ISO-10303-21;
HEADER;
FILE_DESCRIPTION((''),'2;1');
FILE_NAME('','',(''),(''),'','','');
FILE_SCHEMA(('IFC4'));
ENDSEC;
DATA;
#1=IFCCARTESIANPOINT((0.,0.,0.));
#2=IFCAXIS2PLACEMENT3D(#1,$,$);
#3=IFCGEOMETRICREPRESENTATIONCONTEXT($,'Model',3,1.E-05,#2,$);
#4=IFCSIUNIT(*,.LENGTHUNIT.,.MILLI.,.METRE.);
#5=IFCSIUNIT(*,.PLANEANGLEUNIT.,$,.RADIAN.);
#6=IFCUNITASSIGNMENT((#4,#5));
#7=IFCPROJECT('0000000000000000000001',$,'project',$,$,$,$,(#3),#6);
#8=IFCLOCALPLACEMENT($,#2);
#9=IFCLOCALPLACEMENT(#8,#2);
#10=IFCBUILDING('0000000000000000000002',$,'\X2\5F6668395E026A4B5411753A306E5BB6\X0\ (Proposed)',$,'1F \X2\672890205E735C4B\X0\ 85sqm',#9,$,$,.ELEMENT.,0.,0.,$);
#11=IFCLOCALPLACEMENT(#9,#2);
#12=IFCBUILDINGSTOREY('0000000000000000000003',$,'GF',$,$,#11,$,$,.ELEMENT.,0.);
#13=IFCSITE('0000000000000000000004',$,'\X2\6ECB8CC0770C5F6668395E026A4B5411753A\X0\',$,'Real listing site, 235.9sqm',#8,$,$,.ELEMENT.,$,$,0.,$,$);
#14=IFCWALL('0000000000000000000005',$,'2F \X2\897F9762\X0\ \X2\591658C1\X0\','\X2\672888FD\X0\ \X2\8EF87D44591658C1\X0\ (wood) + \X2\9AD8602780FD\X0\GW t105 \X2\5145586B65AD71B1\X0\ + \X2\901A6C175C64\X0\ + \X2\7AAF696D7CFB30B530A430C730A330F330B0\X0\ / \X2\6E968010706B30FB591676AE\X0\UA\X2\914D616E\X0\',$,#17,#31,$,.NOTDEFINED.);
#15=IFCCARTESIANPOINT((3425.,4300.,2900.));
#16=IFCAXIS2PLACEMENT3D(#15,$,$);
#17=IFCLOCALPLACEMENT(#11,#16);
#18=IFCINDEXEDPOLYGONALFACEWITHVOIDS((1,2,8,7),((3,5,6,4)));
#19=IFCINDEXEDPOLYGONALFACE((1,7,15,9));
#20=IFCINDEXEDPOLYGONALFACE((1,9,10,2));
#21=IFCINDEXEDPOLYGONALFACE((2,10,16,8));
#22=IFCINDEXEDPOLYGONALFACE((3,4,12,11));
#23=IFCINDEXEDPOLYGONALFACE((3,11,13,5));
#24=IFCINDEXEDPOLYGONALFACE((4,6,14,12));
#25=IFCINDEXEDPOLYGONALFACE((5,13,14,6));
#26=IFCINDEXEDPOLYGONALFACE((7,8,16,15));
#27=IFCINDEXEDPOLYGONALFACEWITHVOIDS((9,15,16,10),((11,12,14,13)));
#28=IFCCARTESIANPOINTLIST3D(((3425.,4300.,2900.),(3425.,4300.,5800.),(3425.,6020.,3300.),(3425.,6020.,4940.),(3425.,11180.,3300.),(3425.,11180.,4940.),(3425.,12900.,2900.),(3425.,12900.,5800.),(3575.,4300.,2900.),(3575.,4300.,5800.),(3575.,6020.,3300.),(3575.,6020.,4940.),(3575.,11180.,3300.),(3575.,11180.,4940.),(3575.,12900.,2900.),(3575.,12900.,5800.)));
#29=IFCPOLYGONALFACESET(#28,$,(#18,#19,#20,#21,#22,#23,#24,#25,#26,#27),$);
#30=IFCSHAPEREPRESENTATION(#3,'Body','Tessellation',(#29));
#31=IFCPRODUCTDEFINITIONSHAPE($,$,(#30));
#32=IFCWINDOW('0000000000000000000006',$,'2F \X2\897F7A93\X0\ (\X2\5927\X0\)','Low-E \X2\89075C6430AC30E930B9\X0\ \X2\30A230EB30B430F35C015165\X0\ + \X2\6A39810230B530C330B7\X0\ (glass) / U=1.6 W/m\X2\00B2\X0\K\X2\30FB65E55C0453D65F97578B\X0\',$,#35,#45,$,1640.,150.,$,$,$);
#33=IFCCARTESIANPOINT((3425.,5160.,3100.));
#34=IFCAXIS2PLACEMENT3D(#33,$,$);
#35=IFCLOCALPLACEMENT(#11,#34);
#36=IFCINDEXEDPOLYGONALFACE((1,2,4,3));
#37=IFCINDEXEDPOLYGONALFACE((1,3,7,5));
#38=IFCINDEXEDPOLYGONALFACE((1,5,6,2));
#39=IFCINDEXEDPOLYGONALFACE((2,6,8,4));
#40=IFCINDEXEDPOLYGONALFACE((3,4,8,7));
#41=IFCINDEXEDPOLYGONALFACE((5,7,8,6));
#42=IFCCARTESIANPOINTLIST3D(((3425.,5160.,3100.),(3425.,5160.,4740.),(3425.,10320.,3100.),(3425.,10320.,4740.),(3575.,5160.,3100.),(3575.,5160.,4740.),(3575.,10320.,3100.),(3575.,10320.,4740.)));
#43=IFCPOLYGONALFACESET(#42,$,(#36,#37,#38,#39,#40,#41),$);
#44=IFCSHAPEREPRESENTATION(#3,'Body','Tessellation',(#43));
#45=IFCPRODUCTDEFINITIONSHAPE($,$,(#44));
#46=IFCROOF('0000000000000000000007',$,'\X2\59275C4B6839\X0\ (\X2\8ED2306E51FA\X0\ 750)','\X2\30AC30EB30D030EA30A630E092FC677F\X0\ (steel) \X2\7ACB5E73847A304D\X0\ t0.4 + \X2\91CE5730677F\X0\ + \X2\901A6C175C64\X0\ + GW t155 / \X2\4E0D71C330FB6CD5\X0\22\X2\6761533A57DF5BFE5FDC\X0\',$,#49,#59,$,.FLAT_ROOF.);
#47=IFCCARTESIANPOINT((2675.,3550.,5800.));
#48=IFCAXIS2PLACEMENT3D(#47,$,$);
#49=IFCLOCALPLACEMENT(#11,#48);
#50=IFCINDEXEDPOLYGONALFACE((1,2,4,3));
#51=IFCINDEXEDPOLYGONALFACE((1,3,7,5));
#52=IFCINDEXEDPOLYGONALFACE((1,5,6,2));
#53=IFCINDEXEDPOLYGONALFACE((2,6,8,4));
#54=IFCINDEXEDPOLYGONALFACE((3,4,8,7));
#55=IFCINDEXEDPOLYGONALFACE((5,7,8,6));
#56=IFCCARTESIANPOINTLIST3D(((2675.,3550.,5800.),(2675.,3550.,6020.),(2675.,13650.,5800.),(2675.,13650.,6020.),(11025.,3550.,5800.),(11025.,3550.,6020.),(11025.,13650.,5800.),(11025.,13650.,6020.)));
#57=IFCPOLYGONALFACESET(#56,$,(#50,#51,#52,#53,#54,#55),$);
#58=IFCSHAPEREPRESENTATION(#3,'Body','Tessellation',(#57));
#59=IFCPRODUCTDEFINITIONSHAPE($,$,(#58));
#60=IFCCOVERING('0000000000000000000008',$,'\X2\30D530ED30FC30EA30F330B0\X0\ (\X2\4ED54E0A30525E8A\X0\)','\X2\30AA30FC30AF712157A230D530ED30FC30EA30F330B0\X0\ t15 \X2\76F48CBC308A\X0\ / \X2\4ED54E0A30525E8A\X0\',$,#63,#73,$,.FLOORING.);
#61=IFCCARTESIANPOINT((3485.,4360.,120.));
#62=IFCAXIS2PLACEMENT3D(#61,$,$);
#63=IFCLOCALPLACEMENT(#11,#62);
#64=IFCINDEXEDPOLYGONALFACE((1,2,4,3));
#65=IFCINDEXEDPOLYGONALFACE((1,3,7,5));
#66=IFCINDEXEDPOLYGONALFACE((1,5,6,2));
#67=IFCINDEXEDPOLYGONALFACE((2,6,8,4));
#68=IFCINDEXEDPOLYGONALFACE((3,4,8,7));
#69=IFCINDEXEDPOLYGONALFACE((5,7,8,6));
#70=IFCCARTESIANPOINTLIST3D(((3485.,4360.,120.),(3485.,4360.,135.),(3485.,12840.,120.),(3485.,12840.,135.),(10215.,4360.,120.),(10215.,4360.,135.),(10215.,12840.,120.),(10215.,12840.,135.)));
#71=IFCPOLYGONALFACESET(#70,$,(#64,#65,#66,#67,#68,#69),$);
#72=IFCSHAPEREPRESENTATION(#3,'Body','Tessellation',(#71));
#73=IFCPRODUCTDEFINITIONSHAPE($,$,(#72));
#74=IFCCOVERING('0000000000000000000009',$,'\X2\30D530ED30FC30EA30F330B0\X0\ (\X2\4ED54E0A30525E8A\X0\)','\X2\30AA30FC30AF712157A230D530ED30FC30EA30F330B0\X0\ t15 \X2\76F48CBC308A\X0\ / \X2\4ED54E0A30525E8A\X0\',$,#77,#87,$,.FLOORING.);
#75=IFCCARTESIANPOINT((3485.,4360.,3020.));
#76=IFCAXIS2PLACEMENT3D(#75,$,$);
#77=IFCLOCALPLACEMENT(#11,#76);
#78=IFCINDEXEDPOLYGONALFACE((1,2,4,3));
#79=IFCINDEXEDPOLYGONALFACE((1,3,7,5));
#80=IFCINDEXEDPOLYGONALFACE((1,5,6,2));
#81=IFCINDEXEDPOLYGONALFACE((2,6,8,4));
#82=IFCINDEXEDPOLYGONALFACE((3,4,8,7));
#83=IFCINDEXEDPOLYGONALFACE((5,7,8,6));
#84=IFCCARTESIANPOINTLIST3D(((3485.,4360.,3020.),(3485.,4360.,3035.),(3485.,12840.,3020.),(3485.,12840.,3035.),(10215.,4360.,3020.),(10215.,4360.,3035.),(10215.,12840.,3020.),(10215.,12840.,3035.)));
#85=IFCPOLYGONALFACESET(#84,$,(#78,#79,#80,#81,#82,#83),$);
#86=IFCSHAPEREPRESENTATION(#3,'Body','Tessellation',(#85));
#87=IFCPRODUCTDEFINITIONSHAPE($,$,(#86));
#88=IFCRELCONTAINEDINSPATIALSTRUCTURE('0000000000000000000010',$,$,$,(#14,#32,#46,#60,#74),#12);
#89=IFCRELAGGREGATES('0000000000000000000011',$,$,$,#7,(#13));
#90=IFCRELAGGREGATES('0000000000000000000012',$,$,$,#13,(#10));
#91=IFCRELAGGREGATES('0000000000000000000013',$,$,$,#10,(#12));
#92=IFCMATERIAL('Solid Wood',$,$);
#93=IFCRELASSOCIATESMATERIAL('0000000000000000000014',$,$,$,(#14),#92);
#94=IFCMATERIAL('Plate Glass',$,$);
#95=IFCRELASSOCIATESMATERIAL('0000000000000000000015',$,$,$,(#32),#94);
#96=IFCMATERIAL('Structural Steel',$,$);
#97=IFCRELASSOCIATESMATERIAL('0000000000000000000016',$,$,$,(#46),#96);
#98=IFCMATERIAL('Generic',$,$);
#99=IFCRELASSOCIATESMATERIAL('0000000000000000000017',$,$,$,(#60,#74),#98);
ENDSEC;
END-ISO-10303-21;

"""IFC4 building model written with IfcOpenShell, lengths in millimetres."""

from ifc_helpers import new_model, si_unit, frame, frame_2d, origin, place, context, project, spatial, rectangle, extrude, material, element, fill, save


model = new_model("IFC4")

# Units and contexts
model_context = context("Model", 3, precision=1e-05, world=origin())
ifc_project = project(units=[si_unit("LENGTHUNIT", "METRE", prefix="MILLI"), si_unit("PLANEANGLEUNIT", "RADIAN")], contexts=[model_context])

# Site, building, storey
site_placement = place(None, origin())
site = spatial("IfcSite", under=ifc_project, at=site_placement, Name="滋賀県彦根市橋向町", ObjectType="Real listing site, 235.9sqm", CompositionType="ELEMENT", RefElevation=0.0)
building_placement = place(site_placement, origin())
building = spatial("IfcBuilding", under=site, at=building_placement, Name="彦根市橋向町の家 (Proposed)", ObjectType="1F 木造平屋 85sqm", CompositionType="ELEMENT", ElevationOfRefHeight=0.0, ElevationOfTerrain=0.0)
storey_placement = place(building_placement, origin())
storey = spatial("IfcBuildingStorey", under=building, at=storey_placement, Name="GF", CompositionType="ELEMENT", Elevation=0.0)

# Shared definitions
ifc_material_1 = material(Name="Solid Wood")
ifc_material_2 = material(Name="Generic")

# Shared definitions
ifc_material_3 = material(Name="Plate Glass")

# Wall, opening, window
wall_1_placement = place(storey_placement, frame((3425.0, 4300.0, 2900.0)))
wall_1 = element("IfcWall", 1, at=wall_1_placement, inside=storey, material=ifc_material_1, Name="2F 西面 外壁", Description="木製 軸組外壁 (wood) + 高性能GW t105 充填断熱 + 通気層 + 窯業系サイディング / 準耐火・外皮UA配慮", PredefinedType="NOTDEFINED", context=model_context, shape_type="SweptSolid", body=[
    extrude(rectangle(XDim=150.0, YDim=8600.0, at=frame_2d((75.0, 4300.0))), frame((3425.0, 4300.0, 2900.0)), (0.0, 0.0, 1.0), 2900.0),
])
opening_1_placement = place(storey_placement, frame((3425.0, 5160.0, 3100.0)))
opening_1 = element("IfcOpeningElement", 2, at=opening_1_placement, cuts=wall_1, PredefinedType="NOTDEFINED", context=model_context, shape_type="SweptSolid", body=[
    extrude(rectangle(XDim=150.0, YDim=5160.0, at=frame_2d((75.0, 2580.0))), frame((3425.0, 5160.0, 3100.0)), (0.0, 0.0, 1.0), 1640.0),
])
window_1_placement = place(storey_placement, frame((3425.0, 5160.0, 3100.0)))
window_1 = element("IfcWindow", 3, at=window_1_placement, inside=storey, material=ifc_material_3, Name="2F 西窓 (大)", Description="Low-E 複層ガラス アルゴン封入 + 樹脂サッシ (glass) / U=1.6 W/m²K・日射取得型", OverallHeight=1640.0, OverallWidth=150.0, context=model_context, shape_type="SweptSolid", body=[
    extrude(rectangle(XDim=150.0, YDim=5160.0, at=frame_2d((75.0, 2580.0))), frame((3425.0, 5160.0, 3100.0)), (0.0, 0.0, 1.0), 1640.0),
])
fill(opening_1, window_1)

# Roof
ifc_material_4 = material(Name="Structural Steel")
roof_placement = place(storey_placement, frame((2675.0, 3550.0, 5800.0)))
element("IfcRoof", 4, at=roof_placement, inside=storey, material=ifc_material_4, Name="大屋根 (軒の出 750)", Description="ガルバリウム鋼板 (steel) 立平葺き t0.4 + 野地板 + 通気層 + GW t155 / 不燃・法22条区域対応", PredefinedType="FLAT_ROOF", context=model_context, shape_type="SweptSolid", body=[
    extrude(rectangle(XDim=8350.0, YDim=10100.0, at=frame_2d((4175.0, 5050.0))), frame((2675.0, 3550.0, 5800.0)), (0.0, 0.0, 1.0), 220.0),
])

# Coverings
covering_1_placement = place(storey_placement, frame((3485.0, 4360.0, 120.0)))
element("IfcCovering", 5, at=covering_1_placement, inside=storey, material=ifc_material_2, Name="フローリング (仕上げ床)", Description="オーク無垢フローリング t15 直貼り / 仕上げ床", PredefinedType="FLOORING", context=model_context, shape_type="SweptSolid", body=[
    extrude(rectangle(XDim=6730.0, YDim=8480.0, at=frame_2d((3365.0, 4240.0))), frame((3485.0, 4360.0, 120.0)), (0.0, 0.0, 1.0), 15.0),
])
covering_2_placement = place(storey_placement, frame((3485.0, 4360.0, 3020.0)))
element("IfcCovering", 6, at=covering_2_placement, inside=storey, material=ifc_material_2, Name="フローリング (仕上げ床)", Description="オーク無垢フローリング t15 直貼り / 仕上げ床", PredefinedType="FLOORING", context=model_context, shape_type="SweptSolid", body=[
    extrude(rectangle(XDim=6730.0, YDim=8480.0, at=frame_2d((3365.0, 4240.0))), frame((3485.0, 4360.0, 3020.0)), (0.0, 0.0, 1.0), 15.0),
])

save(model, "model.ifc")
